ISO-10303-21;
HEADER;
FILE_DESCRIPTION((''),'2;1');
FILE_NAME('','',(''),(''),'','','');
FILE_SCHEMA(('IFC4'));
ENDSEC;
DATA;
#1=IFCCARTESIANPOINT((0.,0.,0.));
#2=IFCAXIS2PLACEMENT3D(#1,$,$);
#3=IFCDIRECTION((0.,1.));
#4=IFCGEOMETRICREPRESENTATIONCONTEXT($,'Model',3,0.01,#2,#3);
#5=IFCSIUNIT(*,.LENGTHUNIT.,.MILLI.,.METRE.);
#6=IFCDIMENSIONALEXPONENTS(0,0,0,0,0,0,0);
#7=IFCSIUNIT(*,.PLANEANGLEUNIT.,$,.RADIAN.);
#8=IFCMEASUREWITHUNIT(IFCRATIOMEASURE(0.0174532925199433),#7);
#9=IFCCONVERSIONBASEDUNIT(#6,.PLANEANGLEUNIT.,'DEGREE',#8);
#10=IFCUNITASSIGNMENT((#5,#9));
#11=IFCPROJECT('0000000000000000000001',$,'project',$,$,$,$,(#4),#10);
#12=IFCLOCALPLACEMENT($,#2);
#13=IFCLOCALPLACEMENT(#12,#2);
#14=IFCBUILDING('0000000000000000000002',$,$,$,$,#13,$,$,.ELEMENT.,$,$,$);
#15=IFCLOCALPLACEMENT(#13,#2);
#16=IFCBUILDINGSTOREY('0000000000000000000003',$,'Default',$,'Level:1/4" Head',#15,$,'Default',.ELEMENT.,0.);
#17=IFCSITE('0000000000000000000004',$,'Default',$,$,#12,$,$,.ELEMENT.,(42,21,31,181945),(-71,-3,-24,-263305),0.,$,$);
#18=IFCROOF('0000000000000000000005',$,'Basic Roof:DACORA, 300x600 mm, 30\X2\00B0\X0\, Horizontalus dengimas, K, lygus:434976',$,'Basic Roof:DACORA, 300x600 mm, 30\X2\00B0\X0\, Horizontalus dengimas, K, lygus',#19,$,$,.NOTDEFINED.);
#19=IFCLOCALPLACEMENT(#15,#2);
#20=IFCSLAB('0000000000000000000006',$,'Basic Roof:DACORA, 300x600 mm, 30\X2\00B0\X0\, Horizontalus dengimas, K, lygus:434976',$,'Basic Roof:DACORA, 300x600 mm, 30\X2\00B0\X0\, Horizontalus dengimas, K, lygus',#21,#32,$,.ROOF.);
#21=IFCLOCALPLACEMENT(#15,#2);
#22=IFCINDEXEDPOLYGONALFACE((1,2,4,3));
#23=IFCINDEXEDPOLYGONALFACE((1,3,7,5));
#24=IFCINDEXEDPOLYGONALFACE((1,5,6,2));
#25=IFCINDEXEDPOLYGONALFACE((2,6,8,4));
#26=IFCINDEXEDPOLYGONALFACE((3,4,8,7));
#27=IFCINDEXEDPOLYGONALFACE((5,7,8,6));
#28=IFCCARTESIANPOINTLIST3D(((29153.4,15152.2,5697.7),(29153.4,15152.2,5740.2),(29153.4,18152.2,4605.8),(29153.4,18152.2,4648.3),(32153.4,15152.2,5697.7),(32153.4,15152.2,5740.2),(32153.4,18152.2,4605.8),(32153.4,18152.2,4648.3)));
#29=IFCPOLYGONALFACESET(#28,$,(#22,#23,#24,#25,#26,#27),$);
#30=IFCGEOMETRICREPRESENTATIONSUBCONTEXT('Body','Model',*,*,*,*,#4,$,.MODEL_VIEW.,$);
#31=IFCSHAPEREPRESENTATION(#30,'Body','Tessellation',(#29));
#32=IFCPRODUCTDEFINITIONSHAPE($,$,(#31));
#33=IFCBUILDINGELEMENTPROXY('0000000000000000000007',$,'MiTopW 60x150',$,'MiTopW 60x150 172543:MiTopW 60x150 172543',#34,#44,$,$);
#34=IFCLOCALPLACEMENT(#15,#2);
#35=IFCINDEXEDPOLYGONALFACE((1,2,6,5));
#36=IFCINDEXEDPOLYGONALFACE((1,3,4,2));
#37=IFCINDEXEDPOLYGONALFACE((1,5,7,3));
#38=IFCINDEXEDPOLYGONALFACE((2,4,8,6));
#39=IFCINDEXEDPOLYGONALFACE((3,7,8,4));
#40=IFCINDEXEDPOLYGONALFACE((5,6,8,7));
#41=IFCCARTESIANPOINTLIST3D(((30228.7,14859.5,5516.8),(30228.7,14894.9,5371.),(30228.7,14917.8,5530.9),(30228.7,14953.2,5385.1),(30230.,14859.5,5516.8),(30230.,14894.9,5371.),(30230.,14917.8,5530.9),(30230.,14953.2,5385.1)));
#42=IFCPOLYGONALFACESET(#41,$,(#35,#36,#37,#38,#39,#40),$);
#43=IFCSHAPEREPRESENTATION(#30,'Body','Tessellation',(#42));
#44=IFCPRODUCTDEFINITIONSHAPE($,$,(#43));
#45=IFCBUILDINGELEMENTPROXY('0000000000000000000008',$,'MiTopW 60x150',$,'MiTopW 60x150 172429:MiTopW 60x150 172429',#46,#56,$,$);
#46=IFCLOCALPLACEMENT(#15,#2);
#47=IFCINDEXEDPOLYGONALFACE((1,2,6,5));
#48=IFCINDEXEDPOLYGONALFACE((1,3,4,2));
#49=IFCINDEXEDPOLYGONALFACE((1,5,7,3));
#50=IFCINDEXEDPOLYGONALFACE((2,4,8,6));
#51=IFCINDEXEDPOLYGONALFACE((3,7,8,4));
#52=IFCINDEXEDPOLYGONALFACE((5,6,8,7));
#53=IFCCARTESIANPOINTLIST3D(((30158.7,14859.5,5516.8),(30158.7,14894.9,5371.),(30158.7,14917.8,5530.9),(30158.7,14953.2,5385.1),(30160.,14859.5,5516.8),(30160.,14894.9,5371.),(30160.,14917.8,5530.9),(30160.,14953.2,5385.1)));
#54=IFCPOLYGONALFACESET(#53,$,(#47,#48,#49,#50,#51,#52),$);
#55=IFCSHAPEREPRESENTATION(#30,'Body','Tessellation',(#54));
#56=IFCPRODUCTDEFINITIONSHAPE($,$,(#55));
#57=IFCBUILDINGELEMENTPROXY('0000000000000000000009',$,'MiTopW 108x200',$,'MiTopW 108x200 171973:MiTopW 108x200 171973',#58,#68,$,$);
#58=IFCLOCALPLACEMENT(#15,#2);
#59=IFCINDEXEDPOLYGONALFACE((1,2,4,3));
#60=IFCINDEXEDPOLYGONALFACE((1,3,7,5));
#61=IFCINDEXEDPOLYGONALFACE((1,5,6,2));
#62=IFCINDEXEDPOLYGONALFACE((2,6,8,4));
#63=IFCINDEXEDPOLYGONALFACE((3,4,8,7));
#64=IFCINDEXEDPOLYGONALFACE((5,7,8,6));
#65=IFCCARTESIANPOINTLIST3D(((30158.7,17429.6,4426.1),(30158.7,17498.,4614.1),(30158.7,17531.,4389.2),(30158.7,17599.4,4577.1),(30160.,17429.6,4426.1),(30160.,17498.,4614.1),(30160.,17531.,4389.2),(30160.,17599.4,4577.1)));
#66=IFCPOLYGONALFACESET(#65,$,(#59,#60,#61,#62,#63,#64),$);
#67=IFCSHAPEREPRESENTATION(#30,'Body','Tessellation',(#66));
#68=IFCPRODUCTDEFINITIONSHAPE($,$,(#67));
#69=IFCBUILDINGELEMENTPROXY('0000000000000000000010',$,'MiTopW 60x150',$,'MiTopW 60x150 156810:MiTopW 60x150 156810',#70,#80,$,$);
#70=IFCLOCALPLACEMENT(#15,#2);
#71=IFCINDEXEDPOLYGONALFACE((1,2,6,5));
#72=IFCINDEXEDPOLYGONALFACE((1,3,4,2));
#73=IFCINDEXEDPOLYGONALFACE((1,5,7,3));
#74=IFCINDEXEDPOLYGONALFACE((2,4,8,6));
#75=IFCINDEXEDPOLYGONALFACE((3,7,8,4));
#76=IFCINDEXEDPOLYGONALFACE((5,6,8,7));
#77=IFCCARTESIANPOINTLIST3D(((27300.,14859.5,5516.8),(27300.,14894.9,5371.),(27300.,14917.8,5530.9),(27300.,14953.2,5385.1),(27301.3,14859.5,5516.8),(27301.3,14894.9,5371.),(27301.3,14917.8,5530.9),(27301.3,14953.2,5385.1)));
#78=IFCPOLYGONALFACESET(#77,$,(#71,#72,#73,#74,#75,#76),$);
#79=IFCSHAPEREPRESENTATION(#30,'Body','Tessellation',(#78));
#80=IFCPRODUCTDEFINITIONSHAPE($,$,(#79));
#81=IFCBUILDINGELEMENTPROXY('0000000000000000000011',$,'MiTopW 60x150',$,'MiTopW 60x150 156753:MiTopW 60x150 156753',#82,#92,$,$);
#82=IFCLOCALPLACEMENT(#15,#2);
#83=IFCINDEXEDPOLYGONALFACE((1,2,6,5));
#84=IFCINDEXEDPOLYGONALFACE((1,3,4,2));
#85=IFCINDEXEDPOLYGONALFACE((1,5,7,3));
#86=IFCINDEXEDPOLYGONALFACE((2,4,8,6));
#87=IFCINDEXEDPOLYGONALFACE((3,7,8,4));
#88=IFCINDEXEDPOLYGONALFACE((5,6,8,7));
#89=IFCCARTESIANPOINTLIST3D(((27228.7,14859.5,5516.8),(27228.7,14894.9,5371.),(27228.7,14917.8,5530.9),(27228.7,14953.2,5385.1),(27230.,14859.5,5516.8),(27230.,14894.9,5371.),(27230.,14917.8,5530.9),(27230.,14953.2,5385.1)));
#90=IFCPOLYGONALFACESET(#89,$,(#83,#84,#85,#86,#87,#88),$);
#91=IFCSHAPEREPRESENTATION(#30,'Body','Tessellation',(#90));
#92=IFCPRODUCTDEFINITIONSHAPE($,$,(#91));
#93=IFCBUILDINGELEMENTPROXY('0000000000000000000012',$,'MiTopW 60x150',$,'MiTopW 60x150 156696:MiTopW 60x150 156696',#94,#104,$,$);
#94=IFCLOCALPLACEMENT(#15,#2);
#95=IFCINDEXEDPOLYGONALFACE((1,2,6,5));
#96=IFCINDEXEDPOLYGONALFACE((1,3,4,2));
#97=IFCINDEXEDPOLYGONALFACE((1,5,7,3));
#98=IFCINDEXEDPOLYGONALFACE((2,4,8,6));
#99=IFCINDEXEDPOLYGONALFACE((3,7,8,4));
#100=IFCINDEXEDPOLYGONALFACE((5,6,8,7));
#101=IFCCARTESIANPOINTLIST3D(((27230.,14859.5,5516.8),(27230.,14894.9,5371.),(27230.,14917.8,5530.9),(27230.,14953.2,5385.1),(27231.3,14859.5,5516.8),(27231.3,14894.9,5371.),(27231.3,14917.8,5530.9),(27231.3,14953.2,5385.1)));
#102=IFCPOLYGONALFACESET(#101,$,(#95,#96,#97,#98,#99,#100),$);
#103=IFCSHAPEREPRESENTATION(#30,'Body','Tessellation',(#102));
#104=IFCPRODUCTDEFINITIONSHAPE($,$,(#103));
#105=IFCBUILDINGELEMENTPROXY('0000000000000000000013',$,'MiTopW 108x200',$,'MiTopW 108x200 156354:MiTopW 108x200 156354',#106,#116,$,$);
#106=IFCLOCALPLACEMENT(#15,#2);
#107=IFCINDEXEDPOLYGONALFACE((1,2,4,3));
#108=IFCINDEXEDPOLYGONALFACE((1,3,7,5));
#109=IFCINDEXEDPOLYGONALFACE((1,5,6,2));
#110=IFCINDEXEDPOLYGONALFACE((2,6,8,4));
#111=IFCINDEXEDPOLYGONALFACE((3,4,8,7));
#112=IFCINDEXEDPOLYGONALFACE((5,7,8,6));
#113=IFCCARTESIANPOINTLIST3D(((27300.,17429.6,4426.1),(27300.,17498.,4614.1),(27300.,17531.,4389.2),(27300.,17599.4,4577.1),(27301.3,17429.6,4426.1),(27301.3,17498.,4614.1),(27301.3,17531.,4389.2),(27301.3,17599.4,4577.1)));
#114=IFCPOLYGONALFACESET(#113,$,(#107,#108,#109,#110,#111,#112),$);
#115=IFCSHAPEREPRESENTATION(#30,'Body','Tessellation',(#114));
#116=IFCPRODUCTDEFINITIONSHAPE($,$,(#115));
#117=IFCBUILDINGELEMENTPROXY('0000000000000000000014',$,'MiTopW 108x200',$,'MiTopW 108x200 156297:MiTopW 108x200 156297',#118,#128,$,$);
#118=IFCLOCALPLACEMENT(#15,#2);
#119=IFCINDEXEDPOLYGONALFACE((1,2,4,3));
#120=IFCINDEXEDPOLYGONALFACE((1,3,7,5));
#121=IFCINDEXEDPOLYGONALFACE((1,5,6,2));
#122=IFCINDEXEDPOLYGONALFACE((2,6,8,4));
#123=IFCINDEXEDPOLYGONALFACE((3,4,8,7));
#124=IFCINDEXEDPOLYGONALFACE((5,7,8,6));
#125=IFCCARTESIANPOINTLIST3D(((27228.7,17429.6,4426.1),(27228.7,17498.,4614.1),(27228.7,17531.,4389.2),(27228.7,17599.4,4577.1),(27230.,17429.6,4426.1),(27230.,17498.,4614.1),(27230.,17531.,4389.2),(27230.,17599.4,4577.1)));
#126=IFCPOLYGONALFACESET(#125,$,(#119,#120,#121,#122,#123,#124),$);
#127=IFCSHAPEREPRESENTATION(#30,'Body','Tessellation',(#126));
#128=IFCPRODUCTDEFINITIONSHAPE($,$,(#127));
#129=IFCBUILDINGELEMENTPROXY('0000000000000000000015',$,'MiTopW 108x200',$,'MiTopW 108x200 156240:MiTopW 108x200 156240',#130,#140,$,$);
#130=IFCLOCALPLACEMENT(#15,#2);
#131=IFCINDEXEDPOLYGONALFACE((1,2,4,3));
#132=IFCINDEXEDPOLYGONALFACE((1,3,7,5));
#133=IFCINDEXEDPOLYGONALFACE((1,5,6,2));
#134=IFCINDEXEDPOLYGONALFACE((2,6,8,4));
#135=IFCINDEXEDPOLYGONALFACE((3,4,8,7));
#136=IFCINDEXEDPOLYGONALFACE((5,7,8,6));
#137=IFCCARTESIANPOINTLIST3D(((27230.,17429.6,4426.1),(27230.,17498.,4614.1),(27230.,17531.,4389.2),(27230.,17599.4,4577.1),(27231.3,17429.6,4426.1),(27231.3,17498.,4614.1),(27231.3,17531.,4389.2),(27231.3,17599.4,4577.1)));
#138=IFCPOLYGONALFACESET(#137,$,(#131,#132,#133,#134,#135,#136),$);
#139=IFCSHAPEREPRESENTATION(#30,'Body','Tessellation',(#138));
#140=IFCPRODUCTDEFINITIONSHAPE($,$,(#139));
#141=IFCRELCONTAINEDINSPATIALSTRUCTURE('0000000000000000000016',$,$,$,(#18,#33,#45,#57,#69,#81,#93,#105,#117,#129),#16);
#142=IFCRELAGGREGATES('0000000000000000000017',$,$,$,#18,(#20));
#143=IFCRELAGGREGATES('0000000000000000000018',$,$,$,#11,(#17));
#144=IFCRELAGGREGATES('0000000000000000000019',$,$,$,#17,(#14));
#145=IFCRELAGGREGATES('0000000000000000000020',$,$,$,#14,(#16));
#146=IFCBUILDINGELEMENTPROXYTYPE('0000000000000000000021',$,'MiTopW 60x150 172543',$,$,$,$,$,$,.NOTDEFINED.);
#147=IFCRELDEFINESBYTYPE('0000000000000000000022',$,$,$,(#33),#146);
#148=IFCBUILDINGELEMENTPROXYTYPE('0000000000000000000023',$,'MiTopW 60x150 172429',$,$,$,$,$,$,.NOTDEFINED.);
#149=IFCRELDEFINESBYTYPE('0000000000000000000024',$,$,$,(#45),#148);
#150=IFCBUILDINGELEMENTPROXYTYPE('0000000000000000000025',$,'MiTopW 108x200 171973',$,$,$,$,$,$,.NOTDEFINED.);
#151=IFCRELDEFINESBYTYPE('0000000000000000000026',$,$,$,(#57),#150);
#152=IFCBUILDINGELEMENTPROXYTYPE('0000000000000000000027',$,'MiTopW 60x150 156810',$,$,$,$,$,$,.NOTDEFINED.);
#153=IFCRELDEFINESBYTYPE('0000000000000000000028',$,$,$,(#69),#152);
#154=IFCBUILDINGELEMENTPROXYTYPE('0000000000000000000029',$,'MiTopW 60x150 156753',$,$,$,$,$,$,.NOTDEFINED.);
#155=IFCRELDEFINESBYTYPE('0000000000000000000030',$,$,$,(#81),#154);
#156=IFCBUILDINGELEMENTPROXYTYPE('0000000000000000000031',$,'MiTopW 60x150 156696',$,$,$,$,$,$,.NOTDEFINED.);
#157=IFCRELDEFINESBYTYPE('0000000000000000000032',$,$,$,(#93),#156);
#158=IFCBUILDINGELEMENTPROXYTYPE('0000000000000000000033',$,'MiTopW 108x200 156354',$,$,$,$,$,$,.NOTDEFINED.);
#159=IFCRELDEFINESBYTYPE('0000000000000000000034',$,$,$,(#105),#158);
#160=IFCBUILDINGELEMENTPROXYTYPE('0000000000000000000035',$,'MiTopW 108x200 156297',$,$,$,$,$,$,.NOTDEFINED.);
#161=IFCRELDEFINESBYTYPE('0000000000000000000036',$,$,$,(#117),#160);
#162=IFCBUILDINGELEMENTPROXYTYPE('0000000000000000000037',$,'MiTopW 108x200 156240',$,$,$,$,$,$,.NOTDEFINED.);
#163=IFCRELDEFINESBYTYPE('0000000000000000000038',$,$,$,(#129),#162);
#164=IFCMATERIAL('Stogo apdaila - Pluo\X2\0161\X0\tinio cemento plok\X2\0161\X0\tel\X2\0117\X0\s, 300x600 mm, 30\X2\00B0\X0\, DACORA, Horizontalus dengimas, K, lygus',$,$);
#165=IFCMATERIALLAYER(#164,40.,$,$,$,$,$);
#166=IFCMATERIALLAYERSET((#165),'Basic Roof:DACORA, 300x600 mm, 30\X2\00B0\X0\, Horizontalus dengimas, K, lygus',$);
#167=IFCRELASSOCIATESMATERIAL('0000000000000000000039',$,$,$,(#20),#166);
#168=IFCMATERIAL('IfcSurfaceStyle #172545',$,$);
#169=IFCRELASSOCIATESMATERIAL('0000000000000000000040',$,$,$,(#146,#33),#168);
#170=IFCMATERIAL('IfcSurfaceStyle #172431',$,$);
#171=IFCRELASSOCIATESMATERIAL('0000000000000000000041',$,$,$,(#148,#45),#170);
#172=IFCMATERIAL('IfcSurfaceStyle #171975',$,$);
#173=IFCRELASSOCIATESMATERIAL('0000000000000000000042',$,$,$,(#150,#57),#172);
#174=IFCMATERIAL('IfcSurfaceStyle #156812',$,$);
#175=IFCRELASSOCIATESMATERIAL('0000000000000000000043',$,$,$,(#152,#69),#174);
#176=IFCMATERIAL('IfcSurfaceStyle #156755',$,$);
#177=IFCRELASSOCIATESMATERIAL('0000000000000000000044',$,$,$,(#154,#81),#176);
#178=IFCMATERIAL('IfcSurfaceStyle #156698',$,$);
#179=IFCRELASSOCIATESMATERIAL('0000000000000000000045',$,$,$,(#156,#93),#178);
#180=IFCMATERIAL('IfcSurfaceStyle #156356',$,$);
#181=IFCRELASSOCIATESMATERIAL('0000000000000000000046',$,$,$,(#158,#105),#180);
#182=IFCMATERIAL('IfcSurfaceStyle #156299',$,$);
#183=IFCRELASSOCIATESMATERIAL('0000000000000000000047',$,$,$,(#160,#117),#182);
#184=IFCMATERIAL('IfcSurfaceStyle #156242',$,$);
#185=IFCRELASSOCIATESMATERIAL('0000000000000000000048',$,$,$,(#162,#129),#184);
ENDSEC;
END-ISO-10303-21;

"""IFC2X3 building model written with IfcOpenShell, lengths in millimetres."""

from ifc_helpers import new_model, entity, si_unit, converted_unit, direction, frame, frame_2d, origin, place, context, subcontext, project, spatial, polyline, rectangle, outline, extrude, source, transform, mapped, material, layer, layer_set, type_object, type_shapes, element, aggregate, save


model = new_model("IFC2X3")

# Units and contexts
model_context = context("Model", 3, precision=0.01, world=origin(), true_north=direction((0.0, 1.0)))
body_context = subcontext(model_context, "Body", "Model", "MODEL_VIEW")
ifc_project = project(units=[si_unit("LENGTHUNIT", "METRE", prefix="MILLI"), converted_unit("PLANEANGLEUNIT", "DEGREE", entity("IfcRatioMeasure", 0.0174532925199433), si_unit("PLANEANGLEUNIT", "RADIAN"), dimensions=[0, 0, 0, 0, 0, 0, 0])], contexts=[model_context])

# Site, building, storey
site_placement = place(None, origin())
site = spatial("IfcSite", under=ifc_project, at=site_placement, Name="Default", CompositionType="ELEMENT", RefLatitude=(42, 21, 31, 181945), RefLongitude=(-71, -3, -24, -263305), RefElevation=0.0)
building_placement = place(site_placement, origin())
building = spatial("IfcBuilding", under=site, at=building_placement, CompositionType="ELEMENT")
storey_placement = place(building_placement, origin())
storey = spatial("IfcBuildingStorey", under=building, at=storey_placement, Name="Default", ObjectType="Level:1/4\" Head", LongName="Default", CompositionType="ELEMENT", Elevation=0.0)

# Roof, slab
roof_placement = place(storey_placement, frame((29153.4, 15152.2, 4605.8)))
roof = element("IfcRoof", 1, at=roof_placement, inside=storey, Name="Basic Roof:DACORA, 300x600 mm, 30°, Horizontalus dengimas, K, lygus:434976", ObjectType="Basic Roof:DACORA, 300x600 mm, 30°, Horizontalus dengimas, K, lygus", ShapeType="NOTDEFINED")
ifc_material_1 = material(Name="Stogo apdaila - Pluoštinio cemento plokštelės, 300x600 mm, 30°, DACORA, Horizontalus dengimas, K, lygus")
ifc_layer = layer(ifc_material_1, 40.0)
ifc_layer_set = layer_set([ifc_layer], Name="Basic Roof:DACORA, 300x600 mm, 30°, Horizontalus dengimas, K, lygus")
slab_placement = place(roof_placement, origin())
slab = element("IfcSlab", 2, at=slab_placement, material=ifc_layer_set, Name="Basic Roof:DACORA, 300x600 mm, 30°, Horizontalus dengimas, K, lygus:434976", ObjectType="Basic Roof:DACORA, 300x600 mm, 30°, Horizontalus dengimas, K, lygus", PredefinedType="ROOF", context=body_context, shape_type="SweptSolid", body=[
    extrude(rectangle(XDim=3192.5, YDim=3000.0, at=frame_2d((0.0, 0.0), x_axis=(0.0, 1.0))), frame((1500.0, 1500.0, 546.0), z_axis=(0.0, 0.34202, 0.939693), x_axis=(1.0, 0.0, 0.0)), (0.0, -0.34202, 0.939693), 42.6),
])
aggregate(roof, [slab])

# Building element proxies
ifc_material_2 = material(Name="IfcSurfaceStyle #172545")
building_element_proxy_type_1 = type_object("IfcBuildingElementProxyType", Name="MiTopW 60x150 172543", PredefinedType="NOTDEFINED", material=ifc_material_2)
shared_shape_1 = source(origin(), body_context, "Body", "SweptSolid", [
    extrude(outline(polyline([(-75.0, -30.0), (75.0, -30.0), (75.0, 30.0), (-75.0, 30.0), (-75.0, -30.0)])), frame((75.0, 30.0, 0.0), z_axis=(0.0, 0.0, 1.0), x_axis=(-1.0, 0.0, 0.0)), (0.0, 0.0, 1.0), 1.3),
])
type_shapes(building_element_proxy_type_1, [shared_shape_1])
proxy_1_placement = place(building_placement, frame((30230.0, 14917.8, 5530.9), z_axis=(-1.0, 0.0, 0.0), x_axis=(0.0, 0.235626, -0.971844)))
element("IfcBuildingElementProxy", 3, at=proxy_1_placement, inside=storey, type_object=building_element_proxy_type_1, material=ifc_material_2, Name="MiTopW 60x150", ObjectType="MiTopW 60x150 172543:MiTopW 60x150 172543", context=body_context, shape_type="MappedRepresentation", body=[
    mapped(shared_shape_1, transform((0.0, 0.0, 0.0), scale=1.0)),
])
ifc_material_3 = material(Name="IfcSurfaceStyle #172431")
building_element_proxy_type_2 = type_object("IfcBuildingElementProxyType", Name="MiTopW 60x150 172429", PredefinedType="NOTDEFINED", material=ifc_material_3)
shared_shape_2 = source(origin(), body_context, "Body", "SweptSolid", [
    extrude(outline(polyline([(-75.0, -30.0), (75.0, -30.0), (75.0, 30.0), (-75.0, 30.0), (-75.0, -30.0)])), frame((75.0, 30.0, 0.0), z_axis=(0.0, 0.0, 1.0), x_axis=(-1.0, 0.0, 0.0)), (0.0, 0.0, 1.0), 1.3),
])
type_shapes(building_element_proxy_type_2, [shared_shape_2])
proxy_2_placement = place(building_placement, frame((30160.0, 14917.8, 5530.9), z_axis=(-1.0, 0.0, 0.0), x_axis=(0.0, 0.235626, -0.971844)))
element("IfcBuildingElementProxy", 4, at=proxy_2_placement, inside=storey, type_object=building_element_proxy_type_2, material=ifc_material_3, Name="MiTopW 60x150", ObjectType="MiTopW 60x150 172429:MiTopW 60x150 172429", context=body_context, shape_type="MappedRepresentation", body=[
    mapped(shared_shape_2, transform((0.0, 0.0, 0.0), scale=1.0)),
])
ifc_material_4 = material(Name="IfcSurfaceStyle #171975")
building_element_proxy_type_3 = type_object("IfcBuildingElementProxyType", Name="MiTopW 108x200 171973", PredefinedType="NOTDEFINED", material=ifc_material_4)
shared_shape_3 = source(origin(), body_context, "Body", "SweptSolid", [
    extrude(outline(polyline([(-100.0, -54.0), (100.0, -54.0), (100.0, 54.0), (-100.0, 54.0), (-100.0, -54.0)])), frame((100.0, 54.0, 0.0), z_axis=(0.0, 0.0, 1.0), x_axis=(-1.0, 0.0, 0.0)), (0.0, 0.0, 1.0), 1.3),
])
type_shapes(building_element_proxy_type_3, [shared_shape_3])
proxy_3_placement = place(building_placement, frame((30160.0, 17599.4, 4577.1), z_axis=(-1.0, 0.0, 0.0), x_axis=(0.0, -0.34202, -0.939693)))
element("IfcBuildingElementProxy", 5, at=proxy_3_placement, inside=storey, type_object=building_element_proxy_type_3, material=ifc_material_4, Name="MiTopW 108x200", ObjectType="MiTopW 108x200 171973:MiTopW 108x200 171973", context=body_context, shape_type="MappedRepresentation", body=[
    mapped(shared_shape_3, transform((0.0, 0.0, 0.0), scale=1.0)),
])
ifc_material_5 = material(Name="IfcSurfaceStyle #156812")
building_element_proxy_type_4 = type_object("IfcBuildingElementProxyType", Name="MiTopW 60x150 156810", PredefinedType="NOTDEFINED", material=ifc_material_5)
shared_shape_4 = source(origin(), body_context, "Body", "SweptSolid", [
    extrude(outline(polyline([(-75.0, -30.0), (75.0, -30.0), (75.0, 30.0), (-75.0, 30.0), (-75.0, -30.0)])), frame((75.0, 30.0, 0.0), z_axis=(0.0, 0.0, 1.0), x_axis=(-1.0, 0.0, 0.0)), (0.0, 0.0, 1.0), 1.3),
])
type_shapes(building_element_proxy_type_4, [shared_shape_4])
proxy_4_placement = place(building_placement, frame((27301.3, 14917.8, 5530.9), z_axis=(-1.0, 0.0, 0.0), x_axis=(0.0, 0.235626, -0.971844)))
element("IfcBuildingElementProxy", 6, at=proxy_4_placement, inside=storey, type_object=building_element_proxy_type_4, material=ifc_material_5, Name="MiTopW 60x150", ObjectType="MiTopW 60x150 156810:MiTopW 60x150 156810", context=body_context, shape_type="MappedRepresentation", body=[
    mapped(shared_shape_4, transform((0.0, 0.0, 0.0), scale=1.0)),
])
ifc_material_6 = material(Name="IfcSurfaceStyle #156755")
building_element_proxy_type_5 = type_object("IfcBuildingElementProxyType", Name="MiTopW 60x150 156753", PredefinedType="NOTDEFINED", material=ifc_material_6)
shared_shape_5 = source(origin(), body_context, "Body", "SweptSolid", [
    extrude(outline(polyline([(-75.0, -30.0), (75.0, -30.0), (75.0, 30.0), (-75.0, 30.0), (-75.0, -30.0)])), frame((75.0, 30.0, 0.0), z_axis=(0.0, 0.0, 1.0), x_axis=(-1.0, 0.0, 0.0)), (0.0, 0.0, 1.0), 1.3),
])
type_shapes(building_element_proxy_type_5, [shared_shape_5])
proxy_5_placement = place(building_placement, frame((27230.0, 14917.8, 5530.9), z_axis=(-1.0, 0.0, 0.0), x_axis=(0.0, 0.235626, -0.971844)))
element("IfcBuildingElementProxy", 7, at=proxy_5_placement, inside=storey, type_object=building_element_proxy_type_5, material=ifc_material_6, Name="MiTopW 60x150", ObjectType="MiTopW 60x150 156753:MiTopW 60x150 156753", context=body_context, shape_type="MappedRepresentation", body=[
    mapped(shared_shape_5, transform((0.0, 0.0, 0.0), scale=1.0)),
])
ifc_material_7 = material(Name="IfcSurfaceStyle #156698")
building_element_proxy_type_6 = type_object("IfcBuildingElementProxyType", Name="MiTopW 60x150 156696", PredefinedType="NOTDEFINED", material=ifc_material_7)
shared_shape_6 = source(origin(), body_context, "Body", "SweptSolid", [
    extrude(outline(polyline([(-75.0, -30.0), (75.0, -30.0), (75.0, 30.0), (-75.0, 30.0), (-75.0, -30.0)])), frame((75.0, 30.0, 0.0), z_axis=(0.0, 0.0, 1.0), x_axis=(-1.0, 0.0, 0.0)), (0.0, 0.0, 1.0), 1.3),
])
type_shapes(building_element_proxy_type_6, [shared_shape_6])
proxy_6_placement = place(building_placement, frame((27231.3, 14917.8, 5530.9), z_axis=(-1.0, 0.0, 0.0), x_axis=(0.0, 0.235626, -0.971844)))
element("IfcBuildingElementProxy", 8, at=proxy_6_placement, inside=storey, type_object=building_element_proxy_type_6, material=ifc_material_7, Name="MiTopW 60x150", ObjectType="MiTopW 60x150 156696:MiTopW 60x150 156696", context=body_context, shape_type="MappedRepresentation", body=[
    mapped(shared_shape_6, transform((0.0, 0.0, 0.0), scale=1.0)),
])
ifc_material_8 = material(Name="IfcSurfaceStyle #156356")
building_element_proxy_type_7 = type_object("IfcBuildingElementProxyType", Name="MiTopW 108x200 156354", PredefinedType="NOTDEFINED", material=ifc_material_8)
shared_shape_7 = source(origin(), body_context, "Body", "SweptSolid", [
    extrude(outline(polyline([(-100.0, -54.0), (100.0, -54.0), (100.0, 54.0), (-100.0, 54.0), (-100.0, -54.0)])), frame((100.0, 54.0, 0.0), z_axis=(0.0, 0.0, 1.0), x_axis=(-1.0, 0.0, 0.0)), (0.0, 0.0, 1.0), 1.3),
])
type_shapes(building_element_proxy_type_7, [shared_shape_7])
proxy_7_placement = place(building_placement, frame((27301.3, 17599.4, 4577.1), z_axis=(-1.0, 0.0, 0.0), x_axis=(0.0, -0.34202, -0.939693)))
element("IfcBuildingElementProxy", 9, at=proxy_7_placement, inside=storey, type_object=building_element_proxy_type_7, material=ifc_material_8, Name="MiTopW 108x200", ObjectType="MiTopW 108x200 156354:MiTopW 108x200 156354", context=body_context, shape_type="MappedRepresentation", body=[
    mapped(shared_shape_7, transform((0.0, 0.0, 0.0), scale=1.0)),
])
ifc_material_9 = material(Name="IfcSurfaceStyle #156299")
building_element_proxy_type_8 = type_object("IfcBuildingElementProxyType", Name="MiTopW 108x200 156297", PredefinedType="NOTDEFINED", material=ifc_material_9)
shared_shape_8 = source(origin(), body_context, "Body", "SweptSolid", [
    extrude(outline(polyline([(-100.0, -54.0), (100.0, -54.0), (100.0, 54.0), (-100.0, 54.0), (-100.0, -54.0)])), frame((100.0, 54.0, 0.0), z_axis=(0.0, 0.0, 1.0), x_axis=(-1.0, 0.0, 0.0)), (0.0, 0.0, 1.0), 1.3),
])
type_shapes(building_element_proxy_type_8, [shared_shape_8])
proxy_8_placement = place(building_placement, frame((27230.0, 17599.4, 4577.1), z_axis=(-1.0, 0.0, 0.0), x_axis=(0.0, -0.34202, -0.939693)))
element("IfcBuildingElementProxy", 10, at=proxy_8_placement, inside=storey, type_object=building_element_proxy_type_8, material=ifc_material_9, Name="MiTopW 108x200", ObjectType="MiTopW 108x200 156297:MiTopW 108x200 156297", context=body_context, shape_type="MappedRepresentation", body=[
    mapped(shared_shape_8, transform((0.0, 0.0, 0.0), scale=1.0)),
])
ifc_material_10 = material(Name="IfcSurfaceStyle #156242")
building_element_proxy_type_9 = type_object("IfcBuildingElementProxyType", Name="MiTopW 108x200 156240", PredefinedType="NOTDEFINED", material=ifc_material_10)
shared_shape_9 = source(origin(), body_context, "Body", "SweptSolid", [
    extrude(outline(polyline([(-100.0, -54.0), (100.0, -54.0), (100.0, 54.0), (-100.0, 54.0), (-100.0, -54.0)])), frame((100.0, 54.0, 0.0), z_axis=(0.0, 0.0, 1.0), x_axis=(-1.0, 0.0, 0.0)), (0.0, 0.0, 1.0), 1.3),
])
type_shapes(building_element_proxy_type_9, [shared_shape_9])
proxy_9_placement = place(building_placement, frame((27231.3, 17599.4, 4577.1), z_axis=(-1.0, 0.0, 0.0), x_axis=(0.0, -0.34202, -0.939693)))
element("IfcBuildingElementProxy", 11, at=proxy_9_placement, inside=storey, type_object=building_element_proxy_type_9, material=ifc_material_10, Name="MiTopW 108x200", ObjectType="MiTopW 108x200 156240:MiTopW 108x200 156240", context=body_context, shape_type="MappedRepresentation", body=[
    mapped(shared_shape_9, transform((0.0, 0.0, 0.0), scale=1.0)),
])

save(model, "model.ifc")
